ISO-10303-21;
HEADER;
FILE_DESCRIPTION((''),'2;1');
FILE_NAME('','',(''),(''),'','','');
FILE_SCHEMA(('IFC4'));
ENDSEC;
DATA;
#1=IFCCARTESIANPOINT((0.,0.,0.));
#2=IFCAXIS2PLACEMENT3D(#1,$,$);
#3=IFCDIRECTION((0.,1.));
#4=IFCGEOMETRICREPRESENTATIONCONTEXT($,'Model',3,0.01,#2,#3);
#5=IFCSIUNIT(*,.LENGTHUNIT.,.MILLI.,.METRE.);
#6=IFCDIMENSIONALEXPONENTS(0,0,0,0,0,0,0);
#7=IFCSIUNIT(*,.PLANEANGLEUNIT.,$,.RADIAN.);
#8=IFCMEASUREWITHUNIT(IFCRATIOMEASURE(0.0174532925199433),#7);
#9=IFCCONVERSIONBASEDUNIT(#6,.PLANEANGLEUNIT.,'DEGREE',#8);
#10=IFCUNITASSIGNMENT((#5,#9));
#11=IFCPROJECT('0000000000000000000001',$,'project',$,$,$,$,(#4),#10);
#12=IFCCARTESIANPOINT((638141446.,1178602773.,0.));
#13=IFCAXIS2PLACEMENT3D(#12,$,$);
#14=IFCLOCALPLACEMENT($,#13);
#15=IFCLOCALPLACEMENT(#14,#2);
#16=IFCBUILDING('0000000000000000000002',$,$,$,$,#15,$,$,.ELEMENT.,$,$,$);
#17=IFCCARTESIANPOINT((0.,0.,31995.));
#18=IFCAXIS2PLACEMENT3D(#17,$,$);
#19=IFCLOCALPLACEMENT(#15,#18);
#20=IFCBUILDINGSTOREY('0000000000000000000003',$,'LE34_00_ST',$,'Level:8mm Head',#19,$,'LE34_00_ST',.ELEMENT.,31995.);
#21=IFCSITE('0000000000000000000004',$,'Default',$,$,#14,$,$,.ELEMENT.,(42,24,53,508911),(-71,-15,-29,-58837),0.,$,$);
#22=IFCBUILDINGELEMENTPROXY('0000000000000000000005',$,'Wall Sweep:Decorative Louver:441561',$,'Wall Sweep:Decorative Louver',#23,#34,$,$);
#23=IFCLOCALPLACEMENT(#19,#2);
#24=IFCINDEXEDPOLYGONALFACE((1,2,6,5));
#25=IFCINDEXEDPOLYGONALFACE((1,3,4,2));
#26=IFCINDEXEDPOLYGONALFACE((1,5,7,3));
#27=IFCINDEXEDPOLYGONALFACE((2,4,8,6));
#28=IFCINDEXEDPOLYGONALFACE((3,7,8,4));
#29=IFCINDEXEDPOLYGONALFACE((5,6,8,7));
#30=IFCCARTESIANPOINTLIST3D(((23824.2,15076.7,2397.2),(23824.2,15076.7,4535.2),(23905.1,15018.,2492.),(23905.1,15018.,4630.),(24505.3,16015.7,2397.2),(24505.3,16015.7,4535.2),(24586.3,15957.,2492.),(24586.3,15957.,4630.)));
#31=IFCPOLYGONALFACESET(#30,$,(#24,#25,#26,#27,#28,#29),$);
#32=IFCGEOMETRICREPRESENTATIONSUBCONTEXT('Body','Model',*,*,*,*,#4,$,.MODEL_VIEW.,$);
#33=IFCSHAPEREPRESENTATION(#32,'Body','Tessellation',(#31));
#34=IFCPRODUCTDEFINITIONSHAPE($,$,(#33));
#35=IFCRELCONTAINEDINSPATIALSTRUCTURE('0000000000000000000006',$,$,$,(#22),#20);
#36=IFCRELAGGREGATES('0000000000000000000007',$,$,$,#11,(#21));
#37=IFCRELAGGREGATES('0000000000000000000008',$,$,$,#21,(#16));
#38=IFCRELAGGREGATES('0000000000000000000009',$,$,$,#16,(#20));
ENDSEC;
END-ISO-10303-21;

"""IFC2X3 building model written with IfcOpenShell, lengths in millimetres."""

from ifc_helpers import new_model, entity, si_unit, converted_unit, direction, frame, origin, place, context, subcontext, project, spatial, polyline, outline, extrude, element, save


model = new_model("IFC2X3")

# Units and contexts
model_context = context("Model", 3, precision=0.01, world=origin(), true_north=direction((0.0, 1.0)))
body_context = subcontext(model_context, "Body", "Model", "MODEL_VIEW")
ifc_project = project(units=[si_unit("LENGTHUNIT", "METRE", prefix="MILLI"), converted_unit("PLANEANGLEUNIT", "DEGREE", entity("IfcRatioMeasure", 0.0174532925199433), si_unit("PLANEANGLEUNIT", "RADIAN"), dimensions=[0, 0, 0, 0, 0, 0, 0])], contexts=[model_context])

# Site, building, storey
site_placement = place(None, frame((638141446.0, 1178602773.0, 0.0)))
site = spatial("IfcSite", under=ifc_project, at=site_placement, Name="Default", CompositionType="ELEMENT", RefLatitude=(42, 24, 53, 508911), RefLongitude=(-71, -15, -29, -58837), RefElevation=0.0)
building_placement = place(site_placement, origin())
building = spatial("IfcBuilding", under=site, at=building_placement, CompositionType="ELEMENT")
storey_placement = place(building_placement, frame((0.0, 0.0, 31995.0)))
storey = spatial("IfcBuildingStorey", under=building, at=storey_placement, Name="LE34_00_ST", ObjectType="Level:8mm Head", LongName="LE34_00_ST", CompositionType="ELEMENT", Elevation=31995.0)

# Building element proxy
proxy_1_placement = place(storey_placement, origin())
element("IfcBuildingElementProxy", 1, at=proxy_1_placement, inside=storey, Name="Wall Sweep:Decorative Louver:441561", ObjectType="Wall Sweep:Decorative Louver", context=body_context, shape_type="SweptSolid", body=[
    extrude(outline(polyline([(666.6, -775.8), (804.4, -775.8), (-666.6, 775.8), (-804.4, 775.8), (666.6, -775.8)])), frame((23864.7, 15047.3, 3513.6), z_axis=(0.587164, 0.809468, 0.0), x_axis=(0.58745, -0.426119, 0.687986)), (0.0, 0.0, 1.0), 1160.0),
])

save(model, "model.ifc")
